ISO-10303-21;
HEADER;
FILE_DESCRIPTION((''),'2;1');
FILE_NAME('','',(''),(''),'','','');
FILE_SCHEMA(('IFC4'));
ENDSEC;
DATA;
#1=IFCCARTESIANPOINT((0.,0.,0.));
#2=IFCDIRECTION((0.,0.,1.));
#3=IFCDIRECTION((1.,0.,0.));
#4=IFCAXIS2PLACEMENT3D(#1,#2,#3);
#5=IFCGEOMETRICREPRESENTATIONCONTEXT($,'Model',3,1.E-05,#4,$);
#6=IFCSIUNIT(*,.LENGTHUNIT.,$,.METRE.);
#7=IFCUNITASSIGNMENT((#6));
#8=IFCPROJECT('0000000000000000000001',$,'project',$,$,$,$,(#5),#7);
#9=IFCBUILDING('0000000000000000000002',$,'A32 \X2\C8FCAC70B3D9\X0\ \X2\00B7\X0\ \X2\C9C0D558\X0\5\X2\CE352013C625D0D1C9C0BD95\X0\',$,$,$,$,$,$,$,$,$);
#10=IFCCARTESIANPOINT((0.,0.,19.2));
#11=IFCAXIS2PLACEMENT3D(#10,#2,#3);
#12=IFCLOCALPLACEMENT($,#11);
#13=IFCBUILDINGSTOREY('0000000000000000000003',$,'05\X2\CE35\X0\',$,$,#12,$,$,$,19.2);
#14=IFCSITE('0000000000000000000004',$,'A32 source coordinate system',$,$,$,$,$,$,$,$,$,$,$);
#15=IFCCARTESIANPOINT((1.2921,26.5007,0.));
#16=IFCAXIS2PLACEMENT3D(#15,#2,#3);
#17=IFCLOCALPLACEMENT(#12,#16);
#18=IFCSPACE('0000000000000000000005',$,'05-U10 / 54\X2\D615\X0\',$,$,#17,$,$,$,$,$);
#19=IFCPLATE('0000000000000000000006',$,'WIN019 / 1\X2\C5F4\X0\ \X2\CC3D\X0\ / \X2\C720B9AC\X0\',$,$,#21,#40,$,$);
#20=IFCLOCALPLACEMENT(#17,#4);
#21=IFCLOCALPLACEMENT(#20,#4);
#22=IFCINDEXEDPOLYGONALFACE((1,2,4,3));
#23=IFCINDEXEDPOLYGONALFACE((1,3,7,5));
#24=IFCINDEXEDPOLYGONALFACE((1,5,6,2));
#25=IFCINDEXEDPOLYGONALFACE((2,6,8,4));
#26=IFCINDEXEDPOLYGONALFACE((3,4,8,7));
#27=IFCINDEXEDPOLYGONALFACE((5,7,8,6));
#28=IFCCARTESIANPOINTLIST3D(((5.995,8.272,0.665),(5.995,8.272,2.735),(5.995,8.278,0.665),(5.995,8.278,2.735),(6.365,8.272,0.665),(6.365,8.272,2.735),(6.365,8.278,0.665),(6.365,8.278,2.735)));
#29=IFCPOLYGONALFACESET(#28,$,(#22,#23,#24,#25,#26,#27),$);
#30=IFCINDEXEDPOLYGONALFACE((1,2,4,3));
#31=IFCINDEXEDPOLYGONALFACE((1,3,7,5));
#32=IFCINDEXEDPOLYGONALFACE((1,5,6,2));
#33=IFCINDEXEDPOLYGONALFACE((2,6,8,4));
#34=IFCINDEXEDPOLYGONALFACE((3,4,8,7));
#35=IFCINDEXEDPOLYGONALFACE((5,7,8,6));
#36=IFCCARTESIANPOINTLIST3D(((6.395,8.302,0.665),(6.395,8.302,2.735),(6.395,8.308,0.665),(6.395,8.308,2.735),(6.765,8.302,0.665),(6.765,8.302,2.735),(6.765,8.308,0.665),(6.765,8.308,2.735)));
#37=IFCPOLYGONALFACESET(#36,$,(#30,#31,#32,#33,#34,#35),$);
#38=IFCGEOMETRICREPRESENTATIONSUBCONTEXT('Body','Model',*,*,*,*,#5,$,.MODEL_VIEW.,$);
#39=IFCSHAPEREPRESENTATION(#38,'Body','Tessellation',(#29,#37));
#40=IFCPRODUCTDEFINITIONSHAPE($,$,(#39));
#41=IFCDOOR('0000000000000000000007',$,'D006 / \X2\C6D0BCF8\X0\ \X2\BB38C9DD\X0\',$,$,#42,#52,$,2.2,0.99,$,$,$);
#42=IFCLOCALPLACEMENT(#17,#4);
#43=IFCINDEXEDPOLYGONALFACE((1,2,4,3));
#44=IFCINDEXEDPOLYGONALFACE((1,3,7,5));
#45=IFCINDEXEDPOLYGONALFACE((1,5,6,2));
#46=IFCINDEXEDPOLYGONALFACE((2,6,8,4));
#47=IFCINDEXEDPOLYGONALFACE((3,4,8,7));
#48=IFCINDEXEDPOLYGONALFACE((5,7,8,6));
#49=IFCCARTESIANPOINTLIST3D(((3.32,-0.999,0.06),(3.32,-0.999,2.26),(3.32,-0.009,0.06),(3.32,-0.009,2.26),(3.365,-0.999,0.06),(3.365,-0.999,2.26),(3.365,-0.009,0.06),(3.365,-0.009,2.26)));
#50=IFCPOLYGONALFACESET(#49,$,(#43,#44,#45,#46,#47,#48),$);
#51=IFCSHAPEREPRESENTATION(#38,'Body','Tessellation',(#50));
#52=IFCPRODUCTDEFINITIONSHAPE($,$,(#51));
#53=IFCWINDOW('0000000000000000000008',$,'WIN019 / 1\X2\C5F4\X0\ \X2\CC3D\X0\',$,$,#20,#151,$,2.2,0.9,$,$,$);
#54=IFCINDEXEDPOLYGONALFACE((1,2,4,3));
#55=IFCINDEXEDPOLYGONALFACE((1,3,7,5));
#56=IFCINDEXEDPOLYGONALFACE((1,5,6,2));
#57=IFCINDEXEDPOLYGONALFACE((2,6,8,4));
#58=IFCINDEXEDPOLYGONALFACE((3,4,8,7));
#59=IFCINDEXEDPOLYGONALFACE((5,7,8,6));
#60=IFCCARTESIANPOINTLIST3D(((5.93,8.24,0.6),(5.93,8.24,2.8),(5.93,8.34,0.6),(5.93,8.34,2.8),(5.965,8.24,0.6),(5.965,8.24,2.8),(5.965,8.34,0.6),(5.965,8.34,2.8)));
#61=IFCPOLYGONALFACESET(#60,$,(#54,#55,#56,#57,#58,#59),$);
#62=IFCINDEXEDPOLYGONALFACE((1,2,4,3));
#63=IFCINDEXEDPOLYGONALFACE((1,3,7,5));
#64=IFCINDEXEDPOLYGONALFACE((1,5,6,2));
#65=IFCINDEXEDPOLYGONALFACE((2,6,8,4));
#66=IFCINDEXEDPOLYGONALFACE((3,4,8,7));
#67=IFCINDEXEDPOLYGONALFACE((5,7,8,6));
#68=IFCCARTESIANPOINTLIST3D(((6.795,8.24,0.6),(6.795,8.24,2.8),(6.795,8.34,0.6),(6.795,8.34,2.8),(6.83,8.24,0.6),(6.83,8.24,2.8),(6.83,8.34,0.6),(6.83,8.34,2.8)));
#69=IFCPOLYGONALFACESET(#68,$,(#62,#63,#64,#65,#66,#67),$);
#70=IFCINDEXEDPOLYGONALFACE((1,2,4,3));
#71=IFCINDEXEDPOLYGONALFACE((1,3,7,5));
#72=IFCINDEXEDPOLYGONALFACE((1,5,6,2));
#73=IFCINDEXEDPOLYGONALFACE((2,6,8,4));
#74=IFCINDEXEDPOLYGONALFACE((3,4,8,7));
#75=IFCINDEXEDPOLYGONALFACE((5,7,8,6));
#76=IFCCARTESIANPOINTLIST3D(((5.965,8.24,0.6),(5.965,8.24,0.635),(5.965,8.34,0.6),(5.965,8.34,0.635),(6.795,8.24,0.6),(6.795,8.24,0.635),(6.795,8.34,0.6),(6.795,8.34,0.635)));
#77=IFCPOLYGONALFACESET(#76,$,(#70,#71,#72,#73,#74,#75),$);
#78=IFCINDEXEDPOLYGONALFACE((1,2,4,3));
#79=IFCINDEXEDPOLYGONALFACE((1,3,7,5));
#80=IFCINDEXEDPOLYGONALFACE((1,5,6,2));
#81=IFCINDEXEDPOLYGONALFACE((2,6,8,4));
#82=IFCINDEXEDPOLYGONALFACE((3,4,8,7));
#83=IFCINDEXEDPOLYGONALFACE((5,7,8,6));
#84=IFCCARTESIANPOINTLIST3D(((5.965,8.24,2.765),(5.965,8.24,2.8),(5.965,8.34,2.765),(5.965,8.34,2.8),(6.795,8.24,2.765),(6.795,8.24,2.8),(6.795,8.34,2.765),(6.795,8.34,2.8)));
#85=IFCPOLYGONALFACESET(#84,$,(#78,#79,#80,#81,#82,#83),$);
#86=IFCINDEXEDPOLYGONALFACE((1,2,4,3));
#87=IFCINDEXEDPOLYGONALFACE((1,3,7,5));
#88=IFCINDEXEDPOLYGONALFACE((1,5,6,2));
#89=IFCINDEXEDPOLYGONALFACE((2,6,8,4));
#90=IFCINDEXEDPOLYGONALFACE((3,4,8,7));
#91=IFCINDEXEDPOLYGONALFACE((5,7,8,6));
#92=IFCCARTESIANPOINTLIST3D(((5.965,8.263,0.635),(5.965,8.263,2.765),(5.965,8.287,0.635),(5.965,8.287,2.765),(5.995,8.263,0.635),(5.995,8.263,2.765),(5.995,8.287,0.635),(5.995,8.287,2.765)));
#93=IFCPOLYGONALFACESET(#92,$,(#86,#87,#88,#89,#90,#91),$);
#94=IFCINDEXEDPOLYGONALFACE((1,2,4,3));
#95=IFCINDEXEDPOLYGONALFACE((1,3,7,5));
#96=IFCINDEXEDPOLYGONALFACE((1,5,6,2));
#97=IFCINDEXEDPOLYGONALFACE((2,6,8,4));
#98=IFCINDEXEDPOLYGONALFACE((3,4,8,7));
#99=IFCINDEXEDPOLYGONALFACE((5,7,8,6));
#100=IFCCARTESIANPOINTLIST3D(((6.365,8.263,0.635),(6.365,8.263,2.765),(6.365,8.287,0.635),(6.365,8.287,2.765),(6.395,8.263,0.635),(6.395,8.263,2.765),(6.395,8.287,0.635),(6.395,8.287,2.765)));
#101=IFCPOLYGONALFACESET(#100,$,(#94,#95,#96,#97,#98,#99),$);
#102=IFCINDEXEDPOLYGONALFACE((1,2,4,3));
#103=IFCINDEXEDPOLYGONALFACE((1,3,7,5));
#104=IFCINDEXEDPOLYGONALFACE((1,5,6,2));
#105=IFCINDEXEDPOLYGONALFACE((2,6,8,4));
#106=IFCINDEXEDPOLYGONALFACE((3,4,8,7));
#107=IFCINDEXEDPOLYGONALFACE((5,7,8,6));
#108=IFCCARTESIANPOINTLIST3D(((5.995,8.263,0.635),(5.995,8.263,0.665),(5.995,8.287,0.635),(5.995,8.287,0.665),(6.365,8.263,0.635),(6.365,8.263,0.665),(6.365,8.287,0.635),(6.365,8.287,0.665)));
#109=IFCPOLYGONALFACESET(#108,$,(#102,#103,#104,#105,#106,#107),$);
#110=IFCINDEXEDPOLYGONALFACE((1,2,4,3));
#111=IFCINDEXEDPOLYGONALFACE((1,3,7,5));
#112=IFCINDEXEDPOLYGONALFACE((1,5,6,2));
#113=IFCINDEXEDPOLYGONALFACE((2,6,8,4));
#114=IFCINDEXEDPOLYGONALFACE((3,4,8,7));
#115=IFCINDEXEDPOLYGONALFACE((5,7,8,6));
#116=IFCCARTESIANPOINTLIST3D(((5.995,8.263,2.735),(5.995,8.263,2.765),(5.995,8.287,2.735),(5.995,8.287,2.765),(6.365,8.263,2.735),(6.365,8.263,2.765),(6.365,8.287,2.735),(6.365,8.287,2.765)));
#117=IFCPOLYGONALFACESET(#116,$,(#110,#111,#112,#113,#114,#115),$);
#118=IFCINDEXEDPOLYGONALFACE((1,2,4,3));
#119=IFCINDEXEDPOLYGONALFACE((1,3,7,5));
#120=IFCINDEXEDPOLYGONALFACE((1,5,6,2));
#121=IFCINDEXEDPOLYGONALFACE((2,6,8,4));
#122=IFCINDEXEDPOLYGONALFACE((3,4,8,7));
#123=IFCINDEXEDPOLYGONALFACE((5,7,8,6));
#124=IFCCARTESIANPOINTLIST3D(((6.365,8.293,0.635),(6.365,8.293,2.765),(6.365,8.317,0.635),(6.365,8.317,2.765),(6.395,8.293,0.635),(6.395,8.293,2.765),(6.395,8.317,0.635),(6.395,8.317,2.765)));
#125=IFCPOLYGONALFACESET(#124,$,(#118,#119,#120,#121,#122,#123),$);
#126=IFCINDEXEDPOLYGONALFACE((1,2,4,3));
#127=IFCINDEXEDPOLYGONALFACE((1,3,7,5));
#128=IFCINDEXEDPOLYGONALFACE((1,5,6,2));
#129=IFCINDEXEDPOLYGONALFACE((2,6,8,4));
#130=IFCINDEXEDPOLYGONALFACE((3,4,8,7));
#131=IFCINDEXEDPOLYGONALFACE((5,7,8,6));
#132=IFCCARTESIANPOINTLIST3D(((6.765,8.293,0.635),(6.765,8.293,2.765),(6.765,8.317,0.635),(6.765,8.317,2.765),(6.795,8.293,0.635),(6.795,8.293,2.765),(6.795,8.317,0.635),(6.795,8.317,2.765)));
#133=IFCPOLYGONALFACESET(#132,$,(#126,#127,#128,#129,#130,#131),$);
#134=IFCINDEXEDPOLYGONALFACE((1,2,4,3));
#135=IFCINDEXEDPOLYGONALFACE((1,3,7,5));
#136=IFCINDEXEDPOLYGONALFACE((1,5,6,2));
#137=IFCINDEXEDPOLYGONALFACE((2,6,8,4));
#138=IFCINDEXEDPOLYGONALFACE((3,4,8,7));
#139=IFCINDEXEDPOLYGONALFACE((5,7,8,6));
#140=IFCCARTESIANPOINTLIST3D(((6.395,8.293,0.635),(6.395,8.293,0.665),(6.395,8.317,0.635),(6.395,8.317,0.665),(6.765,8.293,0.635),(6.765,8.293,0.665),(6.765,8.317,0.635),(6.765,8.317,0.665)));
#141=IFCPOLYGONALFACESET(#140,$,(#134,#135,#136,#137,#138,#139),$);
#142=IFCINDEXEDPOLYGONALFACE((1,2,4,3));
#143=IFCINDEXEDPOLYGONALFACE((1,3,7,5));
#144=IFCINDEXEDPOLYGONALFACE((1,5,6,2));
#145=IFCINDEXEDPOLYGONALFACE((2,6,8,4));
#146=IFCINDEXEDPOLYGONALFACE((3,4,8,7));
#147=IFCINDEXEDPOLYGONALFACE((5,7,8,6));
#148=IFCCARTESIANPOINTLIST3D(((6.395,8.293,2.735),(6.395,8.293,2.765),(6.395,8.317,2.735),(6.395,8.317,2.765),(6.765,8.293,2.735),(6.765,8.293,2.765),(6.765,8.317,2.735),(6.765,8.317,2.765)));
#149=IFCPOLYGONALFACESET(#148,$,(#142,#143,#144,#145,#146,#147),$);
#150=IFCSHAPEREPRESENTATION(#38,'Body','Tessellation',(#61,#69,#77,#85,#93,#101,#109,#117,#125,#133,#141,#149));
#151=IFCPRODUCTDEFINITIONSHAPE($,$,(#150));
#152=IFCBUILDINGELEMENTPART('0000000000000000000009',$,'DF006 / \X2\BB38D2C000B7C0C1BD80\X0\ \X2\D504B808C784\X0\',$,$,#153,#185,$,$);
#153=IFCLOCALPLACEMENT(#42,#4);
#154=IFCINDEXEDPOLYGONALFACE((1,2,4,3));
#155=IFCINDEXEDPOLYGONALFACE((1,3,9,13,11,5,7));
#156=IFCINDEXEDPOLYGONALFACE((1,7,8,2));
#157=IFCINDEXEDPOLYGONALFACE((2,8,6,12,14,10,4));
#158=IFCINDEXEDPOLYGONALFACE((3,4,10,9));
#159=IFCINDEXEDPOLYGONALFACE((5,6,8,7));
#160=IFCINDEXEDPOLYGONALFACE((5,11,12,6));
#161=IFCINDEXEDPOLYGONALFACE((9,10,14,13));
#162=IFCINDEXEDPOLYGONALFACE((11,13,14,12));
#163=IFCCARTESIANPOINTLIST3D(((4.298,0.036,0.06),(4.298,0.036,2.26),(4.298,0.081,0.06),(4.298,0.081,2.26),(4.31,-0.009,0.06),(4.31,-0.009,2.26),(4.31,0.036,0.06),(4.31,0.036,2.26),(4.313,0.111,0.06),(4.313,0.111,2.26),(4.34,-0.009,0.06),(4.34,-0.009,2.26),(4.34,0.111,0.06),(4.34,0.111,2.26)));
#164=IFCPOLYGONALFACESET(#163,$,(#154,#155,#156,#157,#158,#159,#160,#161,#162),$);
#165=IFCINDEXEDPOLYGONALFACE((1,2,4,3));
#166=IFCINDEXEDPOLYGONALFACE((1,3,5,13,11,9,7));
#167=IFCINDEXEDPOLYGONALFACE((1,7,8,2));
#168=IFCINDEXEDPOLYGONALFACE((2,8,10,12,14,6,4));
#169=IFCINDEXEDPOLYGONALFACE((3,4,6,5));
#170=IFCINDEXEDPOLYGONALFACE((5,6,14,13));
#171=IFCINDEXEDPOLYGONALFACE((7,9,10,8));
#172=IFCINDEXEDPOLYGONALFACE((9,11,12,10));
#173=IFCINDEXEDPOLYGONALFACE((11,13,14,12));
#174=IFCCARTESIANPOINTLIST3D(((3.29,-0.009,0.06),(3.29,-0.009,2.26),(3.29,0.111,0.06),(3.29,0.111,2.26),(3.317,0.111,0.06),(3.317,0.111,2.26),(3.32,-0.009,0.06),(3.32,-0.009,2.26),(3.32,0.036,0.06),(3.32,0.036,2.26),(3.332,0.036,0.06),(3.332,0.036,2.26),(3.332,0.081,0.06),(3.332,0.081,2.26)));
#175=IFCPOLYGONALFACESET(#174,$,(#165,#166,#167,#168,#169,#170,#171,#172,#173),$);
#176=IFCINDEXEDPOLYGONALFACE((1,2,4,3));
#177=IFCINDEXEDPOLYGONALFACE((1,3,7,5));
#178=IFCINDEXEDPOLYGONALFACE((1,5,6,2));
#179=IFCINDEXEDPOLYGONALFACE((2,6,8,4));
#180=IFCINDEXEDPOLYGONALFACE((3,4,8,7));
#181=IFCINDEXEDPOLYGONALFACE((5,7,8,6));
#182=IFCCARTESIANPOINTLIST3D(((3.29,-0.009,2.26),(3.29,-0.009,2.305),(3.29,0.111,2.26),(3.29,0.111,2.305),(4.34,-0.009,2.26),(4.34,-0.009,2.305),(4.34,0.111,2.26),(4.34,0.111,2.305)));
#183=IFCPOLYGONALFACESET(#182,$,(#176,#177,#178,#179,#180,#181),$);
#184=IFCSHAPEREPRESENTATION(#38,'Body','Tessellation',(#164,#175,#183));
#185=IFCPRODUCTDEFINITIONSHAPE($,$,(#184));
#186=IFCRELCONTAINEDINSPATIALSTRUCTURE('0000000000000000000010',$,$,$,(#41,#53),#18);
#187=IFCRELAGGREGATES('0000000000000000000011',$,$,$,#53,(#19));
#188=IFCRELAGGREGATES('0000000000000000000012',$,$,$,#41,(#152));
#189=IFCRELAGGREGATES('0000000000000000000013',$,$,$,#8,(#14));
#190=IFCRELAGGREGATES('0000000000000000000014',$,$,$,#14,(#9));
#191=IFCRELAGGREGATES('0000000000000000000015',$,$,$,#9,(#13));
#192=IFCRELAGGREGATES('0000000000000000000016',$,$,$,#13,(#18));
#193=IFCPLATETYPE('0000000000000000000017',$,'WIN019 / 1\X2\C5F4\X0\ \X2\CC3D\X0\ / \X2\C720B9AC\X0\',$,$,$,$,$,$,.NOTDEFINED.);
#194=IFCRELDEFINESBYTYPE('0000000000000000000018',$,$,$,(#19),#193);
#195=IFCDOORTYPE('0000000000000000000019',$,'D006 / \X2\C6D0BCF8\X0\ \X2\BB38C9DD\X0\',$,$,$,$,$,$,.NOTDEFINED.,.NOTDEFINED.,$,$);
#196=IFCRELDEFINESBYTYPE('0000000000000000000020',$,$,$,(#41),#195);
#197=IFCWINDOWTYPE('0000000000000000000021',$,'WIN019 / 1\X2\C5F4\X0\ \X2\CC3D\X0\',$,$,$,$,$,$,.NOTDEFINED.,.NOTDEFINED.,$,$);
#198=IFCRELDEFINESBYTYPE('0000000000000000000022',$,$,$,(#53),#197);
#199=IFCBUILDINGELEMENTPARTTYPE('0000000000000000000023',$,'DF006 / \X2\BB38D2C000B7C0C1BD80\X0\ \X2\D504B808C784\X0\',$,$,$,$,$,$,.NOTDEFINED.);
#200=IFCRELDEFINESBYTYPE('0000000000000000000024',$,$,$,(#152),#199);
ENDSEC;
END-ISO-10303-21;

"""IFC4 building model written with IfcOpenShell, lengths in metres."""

from ifc_helpers import new_model, si_unit, frame, origin, origin_with_axes, place, context, subcontext, project, spatial, polyline, outline, extrude, source, transform, mapped, type_object, type_shapes, element, aggregate, save


model = new_model("IFC4")

# Units and contexts
model_context = context("Model", 3, precision=1e-05, world=origin_with_axes())
body_context = subcontext(model_context, "Body", "Model", "MODEL_VIEW")
ifc_project = project(units=[si_unit("LENGTHUNIT", "METRE")], contexts=[model_context])

# Plate
storey_placement = place(None, frame((0.0, 0.0, 19.2), z_axis=(0.0, 0.0, 1.0), x_axis=(1.0, 0.0, 0.0)))
space_placement = place(storey_placement, frame((1.2921, 26.5007, 0.0), z_axis=(0.0, 0.0, 1.0), x_axis=(1.0, 0.0, 0.0)))
plate_type_1 = type_object("IfcPlateType", Name="WIN019 / 1열 창 / 유리", PredefinedType="NOTDEFINED")
shared_shape_1 = source(origin(), body_context, "Body", "SweptSolid", [
    extrude(outline(polyline([(5.995, 8.272), (5.995, 8.278), (6.365, 8.278), (6.365, 8.272), (5.995, 8.272)])), frame((0.0, 0.0, 0.665)), (0.0, 0.0, 1.0), 2.07),
    extrude(outline(polyline([(6.395, 8.302), (6.395, 8.308), (6.765, 8.308), (6.765, 8.302), (6.395, 8.302)])), frame((0.0, 0.0, 0.665)), (0.0, 0.0, 1.0), 2.07),
])
type_shapes(plate_type_1, [shared_shape_1])
window_1_placement = place(space_placement, origin_with_axes())
plate_1_placement = place(window_1_placement, origin_with_axes())
plate_1 = element("IfcPlate", 1, at=plate_1_placement, type_object=plate_type_1, Name="WIN019 / 1열 창 / 유리", context=body_context, shape_type="MappedRepresentation", body=[
    mapped(shared_shape_1, transform((0.0, 0.0, 0.0), scale=1.0)),
])

# Site, building, storey, space
site = spatial("IfcSite", under=ifc_project, Name="A32 source coordinate system")
building = spatial("IfcBuilding", under=site, Name="A32 주거동 · 지하5층–옥탑지붕")
storey = spatial("IfcBuildingStorey", under=building, at=storey_placement, Name="05층", Elevation=19.2)
space = spatial("IfcSpace", under=storey, at=space_placement, Name="05-U10 / 54형")

# Door
door_type_1 = type_object("IfcDoorType", Name="D006 / 원본 문짝", OperationType="NOTDEFINED", PredefinedType="NOTDEFINED")
shared_shape_2 = source(origin(), body_context, "Body", "SweptSolid", [
    extrude(outline(polyline([(3.365, -0.999), (3.32, -0.999), (3.32, -0.009), (3.365, -0.009), (3.365, -0.999)])), frame((0.0, 0.0, 0.06)), (0.0, 0.0, 1.0), 2.2),
])
type_shapes(door_type_1, [shared_shape_2])
door_1_placement = place(space_placement, origin_with_axes())
door_1 = element("IfcDoor", 2, at=door_1_placement, inside=space, type_object=door_type_1, Name="D006 / 원본 문짝", OverallHeight=2.2, OverallWidth=0.99, context=body_context, shape_type="MappedRepresentation", body=[
    mapped(shared_shape_2, transform((0.0, 0.0, 0.0), scale=1.0)),
])

# Window
window_type_1 = type_object("IfcWindowType", Name="WIN019 / 1열 창", PartitioningType="NOTDEFINED", PredefinedType="NOTDEFINED")
shared_shape_3 = source(origin(), body_context, "Body", "SweptSolid", [
    extrude(outline(polyline([(5.93, 8.24), (5.93, 8.34), (5.965, 8.34), (5.965, 8.24), (5.93, 8.24)])), frame((0.0, 0.0, 0.6)), (0.0, 0.0, 1.0), 2.2),
    extrude(outline(polyline([(6.795, 8.24), (6.795, 8.34), (6.83, 8.34), (6.83, 8.24), (6.795, 8.24)])), frame((0.0, 0.0, 0.6)), (0.0, 0.0, 1.0), 2.2),
    extrude(outline(polyline([(5.965, 8.24), (5.965, 8.34), (6.795, 8.34), (6.795, 8.24), (5.965, 8.24)])), frame((0.0, 0.0, 0.6)), (0.0, 0.0, 1.0), 0.035),
    extrude(outline(polyline([(5.965, 8.24), (5.965, 8.34), (6.795, 8.34), (6.795, 8.24), (5.965, 8.24)])), frame((0.0, 0.0, 2.765)), (0.0, 0.0, 1.0), 0.035),
    extrude(outline(polyline([(5.965, 8.263), (5.965, 8.287), (5.995, 8.287), (5.995, 8.263), (5.965, 8.263)])), frame((0.0, 0.0, 0.635)), (0.0, 0.0, 1.0), 2.13),
    extrude(outline(polyline([(6.365, 8.263), (6.365, 8.287), (6.395, 8.287), (6.395, 8.263), (6.365, 8.263)])), frame((0.0, 0.0, 0.635)), (0.0, 0.0, 1.0), 2.13),
    extrude(outline(polyline([(5.995, 8.263), (5.995, 8.287), (6.365, 8.287), (6.365, 8.263), (5.995, 8.263)])), frame((0.0, 0.0, 0.635)), (0.0, 0.0, 1.0), 0.03),
    extrude(outline(polyline([(5.995, 8.263), (5.995, 8.287), (6.365, 8.287), (6.365, 8.263), (5.995, 8.263)])), frame((0.0, 0.0, 2.735)), (0.0, 0.0, 1.0), 0.03),
    extrude(outline(polyline([(6.365, 8.293), (6.365, 8.317), (6.395, 8.317), (6.395, 8.293), (6.365, 8.293)])), frame((0.0, 0.0, 0.635)), (0.0, 0.0, 1.0), 2.13),
    extrude(outline(polyline([(6.765, 8.293), (6.765, 8.317), (6.795, 8.317), (6.795, 8.293), (6.765, 8.293)])), frame((0.0, 0.0, 0.635)), (0.0, 0.0, 1.0), 2.13),
    extrude(outline(polyline([(6.395, 8.293), (6.395, 8.317), (6.765, 8.317), (6.765, 8.293), (6.395, 8.293)])), frame((0.0, 0.0, 0.635)), (0.0, 0.0, 1.0), 0.03),
    extrude(outline(polyline([(6.395, 8.293), (6.395, 8.317), (6.765, 8.317), (6.765, 8.293), (6.395, 8.293)])), frame((0.0, 0.0, 2.735)), (0.0, 0.0, 1.0), 0.03),
])
type_shapes(window_type_1, [shared_shape_3])
window_1 = element("IfcWindow", 3, at=window_1_placement, inside=space, type_object=window_type_1, Name="WIN019 / 1열 창", OverallHeight=2.2, OverallWidth=0.9, context=body_context, shape_type="MappedRepresentation", body=[
    mapped(shared_shape_3, transform((0.0, 0.0, 0.0), scale=1.0)),
])
aggregate(window_1, [plate_1])

# Building element part
building_element_part_type_1 = type_object("IfcBuildingElementPartType", Name="DF006 / 문틀·상부 프레임", PredefinedType="NOTDEFINED")
shared_shape_4 = source(origin(), body_context, "Body", "SweptSolid", [
    extrude(outline(polyline([(4.31, -0.009), (4.31, 0.036), (4.298, 0.036), (4.298, 0.081), (4.313, 0.111), (4.34, 0.111), (4.34, -0.009), (4.31, -0.009)])), frame((0.0, 0.0, 0.06)), (0.0, 0.0, 1.0), 2.2),
    extrude(outline(polyline([(3.29, 0.111), (3.317, 0.111), (3.332, 0.081), (3.332, 0.036), (3.32, 0.036), (3.32, -0.009), (3.29, -0.009), (3.29, 0.111)])), frame((0.0, 0.0, 0.06)), (0.0, 0.0, 1.0), 2.2),
    extrude(outline(polyline([(3.29, -0.009), (3.29, 0.111), (4.34, 0.111), (4.34, -0.009), (3.29, -0.009)])), frame((0.0, 0.0, 2.26)), (0.0, 0.0, 1.0), 0.045),
])
type_shapes(building_element_part_type_1, [shared_shape_4])
building_element_part_1_placement = place(door_1_placement, origin_with_axes())
building_element_part_1 = element("IfcBuildingElementPart", 4, at=building_element_part_1_placement, type_object=building_element_part_type_1, Name="DF006 / 문틀·상부 프레임", context=body_context, shape_type="MappedRepresentation", body=[
    mapped(shared_shape_4, transform((0.0, 0.0, 0.0), scale=1.0)),
])
aggregate(door_1, [building_element_part_1])

save(model, "model.ifc")
